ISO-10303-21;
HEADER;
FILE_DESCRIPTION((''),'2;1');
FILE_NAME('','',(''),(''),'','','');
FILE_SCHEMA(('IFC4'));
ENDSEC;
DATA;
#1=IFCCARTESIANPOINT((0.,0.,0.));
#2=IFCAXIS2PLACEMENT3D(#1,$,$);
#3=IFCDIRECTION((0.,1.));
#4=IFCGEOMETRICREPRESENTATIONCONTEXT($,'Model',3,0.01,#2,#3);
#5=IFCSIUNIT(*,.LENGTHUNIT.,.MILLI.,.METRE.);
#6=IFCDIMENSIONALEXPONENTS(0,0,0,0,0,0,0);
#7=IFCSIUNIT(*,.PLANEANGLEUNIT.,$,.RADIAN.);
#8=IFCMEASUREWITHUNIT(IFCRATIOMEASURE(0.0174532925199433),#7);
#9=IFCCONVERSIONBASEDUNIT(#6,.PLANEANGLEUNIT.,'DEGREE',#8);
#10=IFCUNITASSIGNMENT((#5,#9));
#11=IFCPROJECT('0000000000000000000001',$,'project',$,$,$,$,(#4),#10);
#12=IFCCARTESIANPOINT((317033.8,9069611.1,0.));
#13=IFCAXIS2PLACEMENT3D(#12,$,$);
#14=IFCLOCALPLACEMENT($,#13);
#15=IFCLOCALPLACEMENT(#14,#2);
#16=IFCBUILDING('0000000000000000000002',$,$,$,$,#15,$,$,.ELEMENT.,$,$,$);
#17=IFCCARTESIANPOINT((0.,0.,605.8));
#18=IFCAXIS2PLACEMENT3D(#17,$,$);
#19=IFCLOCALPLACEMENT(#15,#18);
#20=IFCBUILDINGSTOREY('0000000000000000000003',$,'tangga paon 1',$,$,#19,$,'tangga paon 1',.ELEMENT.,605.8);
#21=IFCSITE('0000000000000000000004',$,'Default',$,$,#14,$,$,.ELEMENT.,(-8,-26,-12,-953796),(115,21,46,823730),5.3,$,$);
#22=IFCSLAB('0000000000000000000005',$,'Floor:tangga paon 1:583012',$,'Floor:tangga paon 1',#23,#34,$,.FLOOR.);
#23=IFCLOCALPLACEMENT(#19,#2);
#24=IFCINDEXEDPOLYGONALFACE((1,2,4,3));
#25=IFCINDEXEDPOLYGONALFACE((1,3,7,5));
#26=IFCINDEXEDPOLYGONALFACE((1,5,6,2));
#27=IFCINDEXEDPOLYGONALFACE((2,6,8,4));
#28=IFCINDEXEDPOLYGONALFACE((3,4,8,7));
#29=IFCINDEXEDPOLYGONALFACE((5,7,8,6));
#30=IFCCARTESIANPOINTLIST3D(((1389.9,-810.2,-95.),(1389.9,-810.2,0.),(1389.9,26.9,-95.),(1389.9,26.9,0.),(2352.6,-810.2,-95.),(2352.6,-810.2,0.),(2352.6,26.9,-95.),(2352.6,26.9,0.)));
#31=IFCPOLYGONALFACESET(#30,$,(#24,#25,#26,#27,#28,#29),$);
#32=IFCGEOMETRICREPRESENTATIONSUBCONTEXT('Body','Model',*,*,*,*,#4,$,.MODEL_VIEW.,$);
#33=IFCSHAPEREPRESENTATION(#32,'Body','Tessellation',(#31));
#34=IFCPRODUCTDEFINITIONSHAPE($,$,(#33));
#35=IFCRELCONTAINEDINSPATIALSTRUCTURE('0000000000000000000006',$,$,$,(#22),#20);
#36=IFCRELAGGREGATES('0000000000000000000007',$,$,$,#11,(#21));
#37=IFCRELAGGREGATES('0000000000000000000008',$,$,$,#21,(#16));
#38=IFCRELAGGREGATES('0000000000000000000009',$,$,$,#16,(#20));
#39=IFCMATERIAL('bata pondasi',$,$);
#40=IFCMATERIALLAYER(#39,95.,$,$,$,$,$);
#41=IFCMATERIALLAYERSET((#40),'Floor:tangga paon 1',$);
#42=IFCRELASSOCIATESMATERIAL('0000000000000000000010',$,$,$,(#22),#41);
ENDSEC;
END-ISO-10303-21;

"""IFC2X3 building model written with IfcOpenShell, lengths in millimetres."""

from ifc_helpers import new_model, entity, si_unit, converted_unit, direction, frame, origin, origin_2d_with_axis, place, context, subcontext, project, spatial, rectangle, extrude, material, layer, layer_set, layer_usage, element, save


model = new_model("IFC2X3")

# Units and contexts
model_context = context("Model", 3, precision=0.01, world=origin(), true_north=direction((0.0, 1.0)))
body_context = subcontext(model_context, "Body", "Model", "MODEL_VIEW")
ifc_project = project(units=[si_unit("LENGTHUNIT", "METRE", prefix="MILLI"), converted_unit("PLANEANGLEUNIT", "DEGREE", entity("IfcRatioMeasure", 0.0174532925199433), si_unit("PLANEANGLEUNIT", "RADIAN"), dimensions=[0, 0, 0, 0, 0, 0, 0])], contexts=[model_context])

# Site, building, storey
site_placement = place(None, frame((317033.8, 9069611.1, 0.0)))
site = spatial("IfcSite", under=ifc_project, at=site_placement, Name="Default", CompositionType="ELEMENT", RefLatitude=(-8, -26, -12, -953796), RefLongitude=(115, 21, 46, 823730), RefElevation=5.3)
building_placement = place(site_placement, origin())
building = spatial("IfcBuilding", under=site, at=building_placement, CompositionType="ELEMENT")
storey_placement = place(building_placement, frame((0.0, 0.0, 605.8)))
storey = spatial("IfcBuildingStorey", under=building, at=storey_placement, Name="tangga paon 1", LongName="tangga paon 1", CompositionType="ELEMENT", Elevation=605.8)

# Slab
ifc_material = material(Name="bata pondasi")
ifc_layer = layer(ifc_material, 95.0)
ifc_layer_set = layer_set([ifc_layer], Name="Floor:tangga paon 1")
ifc_layer_usage = layer_usage(ifc_layer_set, "AXIS3", "POSITIVE", 0.0)
slab_placement = place(storey_placement, origin())
element("IfcSlab", 1, at=slab_placement, inside=storey, material=ifc_layer_usage, Name="Floor:tangga paon 1:583012", ObjectType="Floor:tangga paon 1", PredefinedType="FLOOR", context=body_context, shape_type="SweptSolid", body=[
    extrude(rectangle(XDim=837.0, YDim=962.7, at=origin_2d_with_axis()), frame((1871.3, -391.6, 0.0), z_axis=(0.0, 0.0, -1.0), x_axis=(0.0, 1.0, 0.0)), (0.0, 0.0, 1.0), 95.0),
])

save(model, "model.ifc")
